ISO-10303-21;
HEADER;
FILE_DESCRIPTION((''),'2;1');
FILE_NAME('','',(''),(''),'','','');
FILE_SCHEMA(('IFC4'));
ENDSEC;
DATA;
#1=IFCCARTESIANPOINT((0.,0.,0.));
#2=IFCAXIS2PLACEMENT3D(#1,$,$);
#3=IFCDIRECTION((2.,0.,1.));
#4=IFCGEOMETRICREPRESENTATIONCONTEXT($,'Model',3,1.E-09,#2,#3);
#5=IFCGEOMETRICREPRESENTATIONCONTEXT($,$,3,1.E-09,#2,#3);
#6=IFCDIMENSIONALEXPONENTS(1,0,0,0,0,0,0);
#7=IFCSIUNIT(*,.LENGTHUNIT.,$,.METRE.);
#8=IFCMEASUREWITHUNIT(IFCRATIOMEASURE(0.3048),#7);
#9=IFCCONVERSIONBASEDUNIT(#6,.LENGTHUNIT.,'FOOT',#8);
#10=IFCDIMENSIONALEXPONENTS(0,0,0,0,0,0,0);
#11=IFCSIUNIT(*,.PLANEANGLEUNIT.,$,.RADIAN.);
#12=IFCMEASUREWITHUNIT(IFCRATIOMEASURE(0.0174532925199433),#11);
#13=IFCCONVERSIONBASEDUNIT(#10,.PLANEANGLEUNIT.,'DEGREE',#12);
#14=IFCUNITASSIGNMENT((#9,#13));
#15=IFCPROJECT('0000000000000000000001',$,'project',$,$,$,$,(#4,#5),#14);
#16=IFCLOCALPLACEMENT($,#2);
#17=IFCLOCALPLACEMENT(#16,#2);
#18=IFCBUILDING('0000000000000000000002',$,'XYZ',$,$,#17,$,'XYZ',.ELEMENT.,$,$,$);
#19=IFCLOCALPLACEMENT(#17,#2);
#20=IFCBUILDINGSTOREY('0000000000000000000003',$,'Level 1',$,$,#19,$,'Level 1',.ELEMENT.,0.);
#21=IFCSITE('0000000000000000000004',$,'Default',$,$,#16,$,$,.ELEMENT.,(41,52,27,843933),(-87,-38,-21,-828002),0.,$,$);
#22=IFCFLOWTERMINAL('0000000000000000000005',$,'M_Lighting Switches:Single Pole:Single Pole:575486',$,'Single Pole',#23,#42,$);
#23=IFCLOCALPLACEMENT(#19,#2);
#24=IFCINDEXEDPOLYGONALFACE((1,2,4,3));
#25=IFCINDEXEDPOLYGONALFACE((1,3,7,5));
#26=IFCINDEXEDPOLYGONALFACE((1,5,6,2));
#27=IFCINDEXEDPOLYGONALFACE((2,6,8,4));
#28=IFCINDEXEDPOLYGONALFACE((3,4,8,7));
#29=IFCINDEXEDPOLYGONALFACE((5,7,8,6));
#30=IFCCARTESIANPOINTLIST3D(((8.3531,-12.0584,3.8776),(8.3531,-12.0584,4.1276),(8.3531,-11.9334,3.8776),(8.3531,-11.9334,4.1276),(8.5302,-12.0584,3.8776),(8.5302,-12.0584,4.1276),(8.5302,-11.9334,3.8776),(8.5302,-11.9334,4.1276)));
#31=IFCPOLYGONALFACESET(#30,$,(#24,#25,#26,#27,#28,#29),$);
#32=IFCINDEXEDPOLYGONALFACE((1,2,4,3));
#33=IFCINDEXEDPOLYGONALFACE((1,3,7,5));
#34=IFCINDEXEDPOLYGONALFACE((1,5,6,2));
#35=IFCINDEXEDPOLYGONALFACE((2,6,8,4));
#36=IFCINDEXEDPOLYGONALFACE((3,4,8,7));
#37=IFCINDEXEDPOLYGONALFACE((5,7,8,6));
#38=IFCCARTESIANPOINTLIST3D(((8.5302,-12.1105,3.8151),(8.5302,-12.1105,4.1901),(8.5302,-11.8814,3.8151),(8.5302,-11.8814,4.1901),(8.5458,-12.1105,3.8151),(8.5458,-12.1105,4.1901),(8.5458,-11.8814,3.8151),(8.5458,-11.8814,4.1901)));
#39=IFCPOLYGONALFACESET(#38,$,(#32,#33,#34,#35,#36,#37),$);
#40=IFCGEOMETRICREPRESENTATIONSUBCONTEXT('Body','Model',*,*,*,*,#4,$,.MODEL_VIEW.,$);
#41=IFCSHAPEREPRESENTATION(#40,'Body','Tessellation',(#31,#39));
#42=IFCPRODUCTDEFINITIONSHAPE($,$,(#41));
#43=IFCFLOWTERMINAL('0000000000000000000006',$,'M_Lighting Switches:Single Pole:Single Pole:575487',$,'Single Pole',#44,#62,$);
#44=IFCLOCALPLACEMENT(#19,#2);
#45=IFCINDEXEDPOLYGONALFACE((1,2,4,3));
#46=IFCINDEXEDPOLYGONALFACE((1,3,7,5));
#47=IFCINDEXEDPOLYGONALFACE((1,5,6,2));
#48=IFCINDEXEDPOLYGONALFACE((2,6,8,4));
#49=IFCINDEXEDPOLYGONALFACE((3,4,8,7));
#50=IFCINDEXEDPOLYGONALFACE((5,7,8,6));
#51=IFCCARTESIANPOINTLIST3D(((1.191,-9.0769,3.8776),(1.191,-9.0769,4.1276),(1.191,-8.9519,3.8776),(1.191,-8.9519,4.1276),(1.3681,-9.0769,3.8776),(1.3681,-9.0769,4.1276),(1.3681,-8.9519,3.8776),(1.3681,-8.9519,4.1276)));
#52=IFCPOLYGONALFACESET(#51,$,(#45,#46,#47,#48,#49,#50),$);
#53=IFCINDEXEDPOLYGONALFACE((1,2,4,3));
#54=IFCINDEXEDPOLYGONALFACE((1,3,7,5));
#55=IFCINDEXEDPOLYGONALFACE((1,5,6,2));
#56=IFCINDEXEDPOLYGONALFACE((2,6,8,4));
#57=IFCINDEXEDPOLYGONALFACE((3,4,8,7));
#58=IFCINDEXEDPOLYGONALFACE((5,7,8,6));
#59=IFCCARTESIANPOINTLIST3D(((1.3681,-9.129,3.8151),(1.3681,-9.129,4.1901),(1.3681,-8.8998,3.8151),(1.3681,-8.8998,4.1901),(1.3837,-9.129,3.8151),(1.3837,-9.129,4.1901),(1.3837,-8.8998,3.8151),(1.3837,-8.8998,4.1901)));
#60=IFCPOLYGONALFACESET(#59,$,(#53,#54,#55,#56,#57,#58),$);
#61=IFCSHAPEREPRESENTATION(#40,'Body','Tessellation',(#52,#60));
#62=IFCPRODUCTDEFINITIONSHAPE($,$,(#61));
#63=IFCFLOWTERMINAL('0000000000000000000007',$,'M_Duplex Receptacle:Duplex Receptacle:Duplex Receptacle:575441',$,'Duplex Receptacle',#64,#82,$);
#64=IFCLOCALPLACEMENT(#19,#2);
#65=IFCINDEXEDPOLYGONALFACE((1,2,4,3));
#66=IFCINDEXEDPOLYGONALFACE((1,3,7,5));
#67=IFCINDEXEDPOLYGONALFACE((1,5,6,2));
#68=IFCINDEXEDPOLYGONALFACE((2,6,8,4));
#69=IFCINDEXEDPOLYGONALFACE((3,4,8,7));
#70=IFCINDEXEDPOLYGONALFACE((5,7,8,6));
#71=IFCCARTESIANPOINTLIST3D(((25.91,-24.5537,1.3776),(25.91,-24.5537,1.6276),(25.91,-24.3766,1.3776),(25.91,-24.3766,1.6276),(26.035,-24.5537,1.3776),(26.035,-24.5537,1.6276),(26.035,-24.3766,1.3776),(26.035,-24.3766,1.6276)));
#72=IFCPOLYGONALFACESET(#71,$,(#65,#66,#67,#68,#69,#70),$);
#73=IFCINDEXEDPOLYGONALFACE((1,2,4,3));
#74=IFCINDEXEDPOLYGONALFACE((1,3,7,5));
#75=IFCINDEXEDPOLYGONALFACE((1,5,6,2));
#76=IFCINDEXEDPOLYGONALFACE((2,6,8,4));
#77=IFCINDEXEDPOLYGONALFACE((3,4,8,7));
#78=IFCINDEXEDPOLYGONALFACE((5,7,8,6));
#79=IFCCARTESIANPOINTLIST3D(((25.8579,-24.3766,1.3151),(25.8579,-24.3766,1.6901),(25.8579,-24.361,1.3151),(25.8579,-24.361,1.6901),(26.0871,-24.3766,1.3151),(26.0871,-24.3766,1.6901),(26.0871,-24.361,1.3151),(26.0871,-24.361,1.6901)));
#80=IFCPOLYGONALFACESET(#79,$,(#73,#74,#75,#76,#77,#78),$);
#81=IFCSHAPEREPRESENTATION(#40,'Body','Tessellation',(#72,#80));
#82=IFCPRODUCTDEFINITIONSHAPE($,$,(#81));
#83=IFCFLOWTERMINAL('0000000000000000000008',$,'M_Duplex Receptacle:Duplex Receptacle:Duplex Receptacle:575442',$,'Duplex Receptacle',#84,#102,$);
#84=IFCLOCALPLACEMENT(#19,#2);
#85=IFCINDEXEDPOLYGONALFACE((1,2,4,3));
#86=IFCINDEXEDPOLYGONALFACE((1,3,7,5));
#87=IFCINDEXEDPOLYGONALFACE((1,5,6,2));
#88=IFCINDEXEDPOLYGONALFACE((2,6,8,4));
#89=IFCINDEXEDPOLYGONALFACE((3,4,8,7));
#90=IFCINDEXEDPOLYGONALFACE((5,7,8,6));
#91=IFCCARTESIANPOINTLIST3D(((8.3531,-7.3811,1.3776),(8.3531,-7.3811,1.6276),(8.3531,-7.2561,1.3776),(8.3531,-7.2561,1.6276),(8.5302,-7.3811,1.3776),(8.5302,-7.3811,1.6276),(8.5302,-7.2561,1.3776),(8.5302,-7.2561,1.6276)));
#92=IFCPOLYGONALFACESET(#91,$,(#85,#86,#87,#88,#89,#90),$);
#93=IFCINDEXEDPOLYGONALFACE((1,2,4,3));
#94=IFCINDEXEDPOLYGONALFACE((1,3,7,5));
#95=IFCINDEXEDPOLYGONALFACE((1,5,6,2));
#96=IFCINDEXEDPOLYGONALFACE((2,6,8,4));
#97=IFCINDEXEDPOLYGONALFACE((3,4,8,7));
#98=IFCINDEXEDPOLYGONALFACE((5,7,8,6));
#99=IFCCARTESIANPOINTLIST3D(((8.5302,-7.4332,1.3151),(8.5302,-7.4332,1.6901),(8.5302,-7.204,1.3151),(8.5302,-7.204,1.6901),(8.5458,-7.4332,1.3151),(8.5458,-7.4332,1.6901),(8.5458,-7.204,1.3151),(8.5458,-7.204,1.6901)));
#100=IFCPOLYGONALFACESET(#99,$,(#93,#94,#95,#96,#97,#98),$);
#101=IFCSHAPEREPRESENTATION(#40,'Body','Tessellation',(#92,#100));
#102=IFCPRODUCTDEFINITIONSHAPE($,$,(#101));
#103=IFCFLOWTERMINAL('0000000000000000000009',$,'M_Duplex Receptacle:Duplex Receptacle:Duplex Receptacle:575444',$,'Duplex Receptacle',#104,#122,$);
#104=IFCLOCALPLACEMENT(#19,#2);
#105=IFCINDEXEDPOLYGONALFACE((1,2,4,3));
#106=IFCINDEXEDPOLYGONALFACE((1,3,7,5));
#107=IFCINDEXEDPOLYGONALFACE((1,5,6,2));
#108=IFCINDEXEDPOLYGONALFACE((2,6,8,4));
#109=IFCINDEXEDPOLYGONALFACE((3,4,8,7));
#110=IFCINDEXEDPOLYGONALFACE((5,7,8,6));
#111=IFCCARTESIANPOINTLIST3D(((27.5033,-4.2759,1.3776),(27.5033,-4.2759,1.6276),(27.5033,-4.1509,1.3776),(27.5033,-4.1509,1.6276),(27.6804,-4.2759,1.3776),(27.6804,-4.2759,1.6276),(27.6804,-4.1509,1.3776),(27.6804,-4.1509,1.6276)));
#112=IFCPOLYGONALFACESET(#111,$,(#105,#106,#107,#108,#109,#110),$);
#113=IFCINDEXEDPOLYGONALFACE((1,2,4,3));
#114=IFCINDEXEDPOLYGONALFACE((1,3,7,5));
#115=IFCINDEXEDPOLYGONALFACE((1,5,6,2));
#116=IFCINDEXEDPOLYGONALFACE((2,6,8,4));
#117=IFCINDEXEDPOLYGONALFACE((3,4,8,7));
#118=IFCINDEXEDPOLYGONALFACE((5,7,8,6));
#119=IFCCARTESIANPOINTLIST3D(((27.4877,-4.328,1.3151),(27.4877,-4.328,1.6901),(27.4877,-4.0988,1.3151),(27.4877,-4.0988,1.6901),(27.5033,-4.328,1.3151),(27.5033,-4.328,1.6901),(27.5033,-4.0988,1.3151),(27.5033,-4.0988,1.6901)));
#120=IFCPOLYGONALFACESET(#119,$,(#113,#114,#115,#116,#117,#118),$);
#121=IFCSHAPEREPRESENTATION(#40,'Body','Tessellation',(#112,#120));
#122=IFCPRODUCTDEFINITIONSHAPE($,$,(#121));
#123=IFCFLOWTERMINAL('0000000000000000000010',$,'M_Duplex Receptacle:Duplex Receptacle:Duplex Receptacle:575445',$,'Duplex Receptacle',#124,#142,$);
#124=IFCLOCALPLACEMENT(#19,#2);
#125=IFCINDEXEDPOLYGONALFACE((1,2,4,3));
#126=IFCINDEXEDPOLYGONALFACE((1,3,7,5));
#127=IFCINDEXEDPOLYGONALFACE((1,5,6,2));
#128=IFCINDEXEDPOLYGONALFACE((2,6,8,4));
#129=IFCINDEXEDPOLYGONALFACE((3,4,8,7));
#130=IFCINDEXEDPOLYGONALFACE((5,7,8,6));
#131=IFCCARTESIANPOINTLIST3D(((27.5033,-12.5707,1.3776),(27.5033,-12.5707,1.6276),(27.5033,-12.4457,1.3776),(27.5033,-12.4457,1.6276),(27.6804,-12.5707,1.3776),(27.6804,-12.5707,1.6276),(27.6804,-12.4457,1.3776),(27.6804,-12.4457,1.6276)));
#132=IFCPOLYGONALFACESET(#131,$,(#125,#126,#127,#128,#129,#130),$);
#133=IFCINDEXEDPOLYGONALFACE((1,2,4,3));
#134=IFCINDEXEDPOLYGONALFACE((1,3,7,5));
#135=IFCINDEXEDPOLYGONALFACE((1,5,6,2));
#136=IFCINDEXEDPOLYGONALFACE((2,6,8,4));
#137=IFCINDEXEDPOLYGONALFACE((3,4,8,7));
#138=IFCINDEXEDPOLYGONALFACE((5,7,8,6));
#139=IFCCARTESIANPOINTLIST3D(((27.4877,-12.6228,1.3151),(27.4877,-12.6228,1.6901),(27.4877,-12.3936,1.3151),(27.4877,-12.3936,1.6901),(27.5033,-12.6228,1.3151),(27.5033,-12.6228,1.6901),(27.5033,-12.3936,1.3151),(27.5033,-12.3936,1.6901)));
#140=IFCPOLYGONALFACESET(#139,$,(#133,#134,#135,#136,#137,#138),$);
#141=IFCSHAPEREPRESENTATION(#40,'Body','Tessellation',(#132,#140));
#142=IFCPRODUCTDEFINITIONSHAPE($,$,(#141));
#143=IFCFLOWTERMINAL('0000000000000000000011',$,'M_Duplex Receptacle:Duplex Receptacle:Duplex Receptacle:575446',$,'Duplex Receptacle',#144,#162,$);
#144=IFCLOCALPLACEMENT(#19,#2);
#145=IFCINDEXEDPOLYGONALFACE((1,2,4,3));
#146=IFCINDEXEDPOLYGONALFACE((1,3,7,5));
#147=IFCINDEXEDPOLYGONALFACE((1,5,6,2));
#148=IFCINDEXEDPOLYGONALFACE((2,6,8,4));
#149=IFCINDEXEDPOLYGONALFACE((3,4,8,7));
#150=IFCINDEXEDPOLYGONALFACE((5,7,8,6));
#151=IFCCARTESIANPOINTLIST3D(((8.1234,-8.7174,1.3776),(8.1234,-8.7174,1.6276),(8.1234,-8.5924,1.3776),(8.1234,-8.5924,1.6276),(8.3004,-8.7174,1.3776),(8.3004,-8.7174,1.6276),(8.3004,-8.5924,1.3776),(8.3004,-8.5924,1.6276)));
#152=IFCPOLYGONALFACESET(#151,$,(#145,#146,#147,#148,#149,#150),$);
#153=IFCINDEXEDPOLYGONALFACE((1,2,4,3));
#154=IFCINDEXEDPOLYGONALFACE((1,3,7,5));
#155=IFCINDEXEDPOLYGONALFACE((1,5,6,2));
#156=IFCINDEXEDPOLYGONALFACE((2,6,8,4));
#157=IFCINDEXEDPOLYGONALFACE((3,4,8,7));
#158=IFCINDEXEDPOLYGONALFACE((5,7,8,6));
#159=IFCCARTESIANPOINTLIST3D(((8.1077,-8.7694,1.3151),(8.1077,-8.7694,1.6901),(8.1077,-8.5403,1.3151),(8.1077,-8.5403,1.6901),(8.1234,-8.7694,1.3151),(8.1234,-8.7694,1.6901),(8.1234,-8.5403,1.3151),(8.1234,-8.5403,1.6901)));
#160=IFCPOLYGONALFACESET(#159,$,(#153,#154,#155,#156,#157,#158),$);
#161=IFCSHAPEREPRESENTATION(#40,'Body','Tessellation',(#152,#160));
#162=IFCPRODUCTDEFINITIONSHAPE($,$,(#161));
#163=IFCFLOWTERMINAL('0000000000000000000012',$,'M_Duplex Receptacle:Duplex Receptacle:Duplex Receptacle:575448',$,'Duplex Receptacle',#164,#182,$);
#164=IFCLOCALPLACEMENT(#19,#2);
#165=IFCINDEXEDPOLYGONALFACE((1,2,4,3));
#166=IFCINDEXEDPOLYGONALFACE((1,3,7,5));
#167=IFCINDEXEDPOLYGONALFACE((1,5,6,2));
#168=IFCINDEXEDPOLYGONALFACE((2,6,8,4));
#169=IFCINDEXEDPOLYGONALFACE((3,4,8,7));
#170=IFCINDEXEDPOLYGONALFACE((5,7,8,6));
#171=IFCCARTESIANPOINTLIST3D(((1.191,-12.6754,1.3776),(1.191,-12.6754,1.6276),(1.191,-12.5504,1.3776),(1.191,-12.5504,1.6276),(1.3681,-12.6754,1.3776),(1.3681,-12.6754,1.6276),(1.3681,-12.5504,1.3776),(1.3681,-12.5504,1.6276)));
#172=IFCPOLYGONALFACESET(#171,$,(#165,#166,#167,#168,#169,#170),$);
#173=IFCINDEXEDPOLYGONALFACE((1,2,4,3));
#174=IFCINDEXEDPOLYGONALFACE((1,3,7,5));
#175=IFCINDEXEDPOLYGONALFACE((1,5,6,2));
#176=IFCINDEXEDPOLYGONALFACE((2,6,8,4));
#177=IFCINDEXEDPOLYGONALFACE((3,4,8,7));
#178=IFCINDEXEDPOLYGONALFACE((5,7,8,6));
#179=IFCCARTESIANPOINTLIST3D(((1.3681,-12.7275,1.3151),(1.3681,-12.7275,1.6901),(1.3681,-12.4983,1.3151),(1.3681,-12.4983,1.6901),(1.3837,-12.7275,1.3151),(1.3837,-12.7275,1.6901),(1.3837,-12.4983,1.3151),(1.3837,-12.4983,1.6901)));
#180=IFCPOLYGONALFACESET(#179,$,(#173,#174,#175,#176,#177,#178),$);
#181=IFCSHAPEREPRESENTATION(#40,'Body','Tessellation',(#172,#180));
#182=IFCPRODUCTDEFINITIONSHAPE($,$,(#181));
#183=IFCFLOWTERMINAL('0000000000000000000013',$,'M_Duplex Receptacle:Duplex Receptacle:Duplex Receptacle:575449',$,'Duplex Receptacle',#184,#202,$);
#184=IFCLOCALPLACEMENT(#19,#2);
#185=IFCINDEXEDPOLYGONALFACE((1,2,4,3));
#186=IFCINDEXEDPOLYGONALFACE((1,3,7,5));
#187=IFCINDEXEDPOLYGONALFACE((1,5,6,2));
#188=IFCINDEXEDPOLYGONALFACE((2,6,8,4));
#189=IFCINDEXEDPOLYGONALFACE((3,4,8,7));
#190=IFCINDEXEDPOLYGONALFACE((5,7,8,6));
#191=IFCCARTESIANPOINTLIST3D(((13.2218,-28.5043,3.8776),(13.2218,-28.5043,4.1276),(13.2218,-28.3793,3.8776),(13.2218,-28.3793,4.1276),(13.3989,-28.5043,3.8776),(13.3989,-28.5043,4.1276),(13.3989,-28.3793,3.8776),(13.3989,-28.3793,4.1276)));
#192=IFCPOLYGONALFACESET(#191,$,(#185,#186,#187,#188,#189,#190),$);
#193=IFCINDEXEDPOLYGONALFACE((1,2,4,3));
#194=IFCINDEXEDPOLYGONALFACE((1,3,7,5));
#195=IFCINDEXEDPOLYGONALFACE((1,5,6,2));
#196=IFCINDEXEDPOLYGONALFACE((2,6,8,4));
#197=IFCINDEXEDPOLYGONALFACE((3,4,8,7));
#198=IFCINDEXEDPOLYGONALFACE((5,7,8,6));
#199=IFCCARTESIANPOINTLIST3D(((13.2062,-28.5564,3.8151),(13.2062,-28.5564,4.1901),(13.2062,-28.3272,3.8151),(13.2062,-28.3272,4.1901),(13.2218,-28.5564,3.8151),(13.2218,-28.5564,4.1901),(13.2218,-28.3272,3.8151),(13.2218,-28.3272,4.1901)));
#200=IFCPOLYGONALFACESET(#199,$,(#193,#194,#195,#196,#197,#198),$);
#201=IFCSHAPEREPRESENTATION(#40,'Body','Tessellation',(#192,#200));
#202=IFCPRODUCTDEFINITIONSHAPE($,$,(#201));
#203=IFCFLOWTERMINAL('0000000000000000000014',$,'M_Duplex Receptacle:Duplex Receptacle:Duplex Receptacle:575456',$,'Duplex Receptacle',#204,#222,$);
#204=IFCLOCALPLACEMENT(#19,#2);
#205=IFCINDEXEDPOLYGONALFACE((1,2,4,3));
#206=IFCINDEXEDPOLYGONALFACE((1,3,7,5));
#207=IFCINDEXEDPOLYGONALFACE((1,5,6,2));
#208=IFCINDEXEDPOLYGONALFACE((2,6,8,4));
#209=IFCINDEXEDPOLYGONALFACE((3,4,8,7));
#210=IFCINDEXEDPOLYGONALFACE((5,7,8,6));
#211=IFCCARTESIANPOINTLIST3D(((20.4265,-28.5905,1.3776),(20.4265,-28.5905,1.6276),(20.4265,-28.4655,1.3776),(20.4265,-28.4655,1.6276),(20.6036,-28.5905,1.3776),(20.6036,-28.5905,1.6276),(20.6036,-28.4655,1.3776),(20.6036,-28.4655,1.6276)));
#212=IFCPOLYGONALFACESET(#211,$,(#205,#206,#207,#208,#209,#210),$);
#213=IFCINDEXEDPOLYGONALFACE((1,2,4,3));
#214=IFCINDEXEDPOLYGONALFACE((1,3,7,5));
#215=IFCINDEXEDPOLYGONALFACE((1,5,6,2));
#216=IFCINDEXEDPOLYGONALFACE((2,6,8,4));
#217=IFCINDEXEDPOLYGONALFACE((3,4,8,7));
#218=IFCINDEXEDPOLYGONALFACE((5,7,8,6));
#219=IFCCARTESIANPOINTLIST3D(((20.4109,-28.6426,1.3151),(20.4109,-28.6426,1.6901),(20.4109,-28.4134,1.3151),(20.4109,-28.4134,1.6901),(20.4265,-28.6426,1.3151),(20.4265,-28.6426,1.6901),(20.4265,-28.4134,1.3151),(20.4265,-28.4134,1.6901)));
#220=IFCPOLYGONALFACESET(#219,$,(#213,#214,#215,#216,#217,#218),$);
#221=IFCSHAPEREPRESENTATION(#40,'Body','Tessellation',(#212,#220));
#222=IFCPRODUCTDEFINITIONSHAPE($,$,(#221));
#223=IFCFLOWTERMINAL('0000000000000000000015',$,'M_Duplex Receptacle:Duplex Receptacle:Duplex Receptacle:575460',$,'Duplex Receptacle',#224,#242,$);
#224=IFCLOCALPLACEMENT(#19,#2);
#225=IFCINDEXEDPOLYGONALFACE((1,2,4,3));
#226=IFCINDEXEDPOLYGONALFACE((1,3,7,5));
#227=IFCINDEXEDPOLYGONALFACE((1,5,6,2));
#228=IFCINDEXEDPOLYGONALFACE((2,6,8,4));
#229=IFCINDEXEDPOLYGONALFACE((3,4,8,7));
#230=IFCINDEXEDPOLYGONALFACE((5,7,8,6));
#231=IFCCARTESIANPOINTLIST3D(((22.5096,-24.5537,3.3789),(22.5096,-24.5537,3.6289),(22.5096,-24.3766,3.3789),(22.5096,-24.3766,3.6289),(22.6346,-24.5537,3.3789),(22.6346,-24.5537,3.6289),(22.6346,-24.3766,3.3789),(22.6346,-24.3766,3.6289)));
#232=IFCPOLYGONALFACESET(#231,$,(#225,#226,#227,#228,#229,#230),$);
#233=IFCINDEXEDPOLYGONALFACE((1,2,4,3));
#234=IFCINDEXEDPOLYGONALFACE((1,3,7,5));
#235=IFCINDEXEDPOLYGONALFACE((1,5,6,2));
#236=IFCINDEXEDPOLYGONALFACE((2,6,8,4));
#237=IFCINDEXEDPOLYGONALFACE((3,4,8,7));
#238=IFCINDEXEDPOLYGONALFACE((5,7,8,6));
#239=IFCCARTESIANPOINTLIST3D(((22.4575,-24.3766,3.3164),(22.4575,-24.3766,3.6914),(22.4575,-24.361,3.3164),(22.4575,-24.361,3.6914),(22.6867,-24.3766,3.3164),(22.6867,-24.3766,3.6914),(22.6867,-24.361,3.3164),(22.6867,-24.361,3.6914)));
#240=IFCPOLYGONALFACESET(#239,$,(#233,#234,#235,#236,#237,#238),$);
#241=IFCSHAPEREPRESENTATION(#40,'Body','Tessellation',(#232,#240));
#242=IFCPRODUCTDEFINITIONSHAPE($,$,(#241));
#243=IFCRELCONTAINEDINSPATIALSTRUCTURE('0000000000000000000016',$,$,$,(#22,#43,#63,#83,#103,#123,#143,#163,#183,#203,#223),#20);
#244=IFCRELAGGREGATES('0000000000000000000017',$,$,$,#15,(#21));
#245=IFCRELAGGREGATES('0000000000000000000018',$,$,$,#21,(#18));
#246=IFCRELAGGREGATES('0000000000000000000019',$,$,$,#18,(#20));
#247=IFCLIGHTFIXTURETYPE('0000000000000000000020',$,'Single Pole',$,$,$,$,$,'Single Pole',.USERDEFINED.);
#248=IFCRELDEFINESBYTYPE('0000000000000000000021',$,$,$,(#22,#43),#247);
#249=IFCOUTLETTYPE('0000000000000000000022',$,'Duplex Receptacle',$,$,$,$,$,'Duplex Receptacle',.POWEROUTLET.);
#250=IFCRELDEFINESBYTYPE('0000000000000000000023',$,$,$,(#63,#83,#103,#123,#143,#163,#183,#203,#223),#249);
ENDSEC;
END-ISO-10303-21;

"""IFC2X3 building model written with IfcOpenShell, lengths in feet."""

from ifc_helpers import new_model, entity, si_unit, converted_unit, direction, frame, frame_2d, origin, origin_2d_with_axis, place, context, subcontext, project, spatial, rectangle, extrude, source, transform, mapped, type_object, type_shapes, element, save


model = new_model("IFC2X3")

# Units and contexts
model_context = context("Model", 3, precision=1e-09, world=origin(), true_north=direction((2.0, 0.0, 1.0)))
context_of_model = context(None, 3, precision=1e-09, world=origin(), true_north=direction((2.0, 0.0, 1.0)))
body_context = subcontext(model_context, "Body", "Model", "MODEL_VIEW")
ifc_project = project(units=[converted_unit("LENGTHUNIT", "FOOT", entity("IfcRatioMeasure", 0.3048), si_unit("LENGTHUNIT", "METRE"), dimensions=[1, 0, 0, 0, 0, 0, 0]), converted_unit("PLANEANGLEUNIT", "DEGREE", entity("IfcRatioMeasure", 0.0174532925199433), si_unit("PLANEANGLEUNIT", "RADIAN"), dimensions=[0, 0, 0, 0, 0, 0, 0])], contexts=[model_context, context_of_model])

# Site, building, storey
site_placement = place(None, origin())
site = spatial("IfcSite", under=ifc_project, at=site_placement, Name="Default", CompositionType="ELEMENT", RefLatitude=(41, 52, 27, 843933), RefLongitude=(-87, -38, -21, -828002), RefElevation=0.0)
building_placement = place(site_placement, origin())
building = spatial("IfcBuilding", under=site, at=building_placement, Name="XYZ", LongName="XYZ", CompositionType="ELEMENT")
storey_placement = place(building_placement, origin())
storey = spatial("IfcBuildingStorey", under=building, at=storey_placement, Name="Level 1", LongName="Level 1", CompositionType="ELEMENT", Elevation=0.0)

# Flow terminals
light_fixture_type = type_object("IfcLightFixtureType", Name="Single Pole", ElementType="Single Pole", PredefinedType="USERDEFINED")
shared_shape_1 = source(origin(), body_context, "Body", "SweptSolid", [
    extrude(rectangle(XDim=0.125, YDim=0.25, at=origin_2d_with_axis()), frame((0.0, 0.0, -0.1771), z_axis=(0.0, 0.0, 1.0), x_axis=(-1.0, 0.0, 0.0)), (0.0, 0.0, 1.0), 0.1771),
    extrude(rectangle(XDim=0.2292, YDim=0.375, at=frame_2d((0.0, 0.0), x_axis=(1.0, 0.0))), frame((0.0, 0.0, 0.0), z_axis=(0.0, 0.0, 1.0), x_axis=(-1.0, 0.0, 0.0)), (0.0, 0.0, 1.0), 0.0156),
])
type_shapes(light_fixture_type, [shared_shape_1])
for number, where, z_axis, x_axis, name in (
    (1, (8.5302, -11.9959, 4.0026), (1.0, 0.0, 0.0), (0.0, 1.0, 0.0), "M_Lighting Switches:Single Pole:Single Pole:575486"),
    (2, (1.3681, -9.0144, 4.0026), (1.0, 0.0, 0.0), (0.0, 1.0, 0.0), "M_Lighting Switches:Single Pole:Single Pole:575487"),
):
    element("IfcFlowTerminal", number, at=place(storey_placement, frame(where, z_axis=z_axis, x_axis=x_axis)), inside=storey, type_object=light_fixture_type, Name=name, ObjectType="Single Pole", context=body_context, shape_type="MappedRepresentation", body=[
        mapped(shared_shape_1, transform((0.0, 0.0, 0.0), scale=1.0)),
    ])
outlet_type = type_object("IfcOutletType", Name="Duplex Receptacle", ElementType="Duplex Receptacle", PredefinedType="POWEROUTLET")
shared_shape_2 = source(origin(), body_context, "Body", "SweptSolid", [
    extrude(rectangle(XDim=0.125, YDim=0.25, at=origin_2d_with_axis()), frame((0.0, 0.0, -0.1771), z_axis=(0.0, 0.0, 1.0), x_axis=(-1.0, 0.0, 0.0)), (0.0, 0.0, 1.0), 0.1771),
    extrude(rectangle(XDim=0.2292, YDim=0.375, at=frame_2d((0.0, 0.0), x_axis=(1.0, 0.0))), frame((0.0, 0.0, 0.0), z_axis=(0.0, 0.0, 1.0), x_axis=(-1.0, 0.0, 0.0)), (0.0, 0.0, 1.0), 0.0156),
])
type_shapes(outlet_type, [shared_shape_2])
for number, where, z_axis, x_axis, name in (
    (3, (25.9725, -24.3766, 1.5026), (0.0, 1.0, 0.0), (-1.0, 0.0, 0.0), "M_Duplex Receptacle:Duplex Receptacle:Duplex Receptacle:575441"),
    (4, (8.5302, -7.3186, 1.5026), (1.0, 0.0, 0.0), (0.0, 1.0, 0.0), "M_Duplex Receptacle:Duplex Receptacle:Duplex Receptacle:575442"),
    (5, (27.5033, -4.2134, 1.5026), (-1.0, 0.0, 0.0), (0.0, -1.0, 0.0), "M_Duplex Receptacle:Duplex Receptacle:Duplex Receptacle:575444"),
    (6, (27.5033, -12.5082, 1.5026), (-1.0, 0.0, 0.0), (0.0, -1.0, 0.0), "M_Duplex Receptacle:Duplex Receptacle:Duplex Receptacle:575445"),
    (7, (8.1234, -8.6549, 1.5026), (-1.0, 0.0, 0.0), (0.0, -1.0, 0.0), "M_Duplex Receptacle:Duplex Receptacle:Duplex Receptacle:575446"),
    (8, (1.3681, -12.6129, 1.5026), (1.0, 0.0, 0.0), (0.0, 1.0, 0.0), "M_Duplex Receptacle:Duplex Receptacle:Duplex Receptacle:575448"),
    (9, (13.2218, -28.4418, 4.0026), (-1.0, 0.0, 0.0), (0.0, -1.0, 0.0), "M_Duplex Receptacle:Duplex Receptacle:Duplex Receptacle:575449"),
    (10, (20.4265, -28.528, 1.5026), (-1.0, 0.0, 0.0), (0.0, -1.0, 0.0), "M_Duplex Receptacle:Duplex Receptacle:Duplex Receptacle:575456"),
    (11, (22.5721, -24.3766, 3.5039), (0.0, 1.0, 0.0), (-1.0, 0.0, 0.0), "M_Duplex Receptacle:Duplex Receptacle:Duplex Receptacle:575460"),
):
    element("IfcFlowTerminal", number, at=place(storey_placement, frame(where, z_axis=z_axis, x_axis=x_axis)), inside=storey, type_object=outlet_type, Name=name, ObjectType="Duplex Receptacle", context=body_context, shape_type="MappedRepresentation", body=[
        mapped(shared_shape_2, transform((0.0, 0.0, 0.0), scale=1.0)),
    ])

save(model, "model.ifc")
